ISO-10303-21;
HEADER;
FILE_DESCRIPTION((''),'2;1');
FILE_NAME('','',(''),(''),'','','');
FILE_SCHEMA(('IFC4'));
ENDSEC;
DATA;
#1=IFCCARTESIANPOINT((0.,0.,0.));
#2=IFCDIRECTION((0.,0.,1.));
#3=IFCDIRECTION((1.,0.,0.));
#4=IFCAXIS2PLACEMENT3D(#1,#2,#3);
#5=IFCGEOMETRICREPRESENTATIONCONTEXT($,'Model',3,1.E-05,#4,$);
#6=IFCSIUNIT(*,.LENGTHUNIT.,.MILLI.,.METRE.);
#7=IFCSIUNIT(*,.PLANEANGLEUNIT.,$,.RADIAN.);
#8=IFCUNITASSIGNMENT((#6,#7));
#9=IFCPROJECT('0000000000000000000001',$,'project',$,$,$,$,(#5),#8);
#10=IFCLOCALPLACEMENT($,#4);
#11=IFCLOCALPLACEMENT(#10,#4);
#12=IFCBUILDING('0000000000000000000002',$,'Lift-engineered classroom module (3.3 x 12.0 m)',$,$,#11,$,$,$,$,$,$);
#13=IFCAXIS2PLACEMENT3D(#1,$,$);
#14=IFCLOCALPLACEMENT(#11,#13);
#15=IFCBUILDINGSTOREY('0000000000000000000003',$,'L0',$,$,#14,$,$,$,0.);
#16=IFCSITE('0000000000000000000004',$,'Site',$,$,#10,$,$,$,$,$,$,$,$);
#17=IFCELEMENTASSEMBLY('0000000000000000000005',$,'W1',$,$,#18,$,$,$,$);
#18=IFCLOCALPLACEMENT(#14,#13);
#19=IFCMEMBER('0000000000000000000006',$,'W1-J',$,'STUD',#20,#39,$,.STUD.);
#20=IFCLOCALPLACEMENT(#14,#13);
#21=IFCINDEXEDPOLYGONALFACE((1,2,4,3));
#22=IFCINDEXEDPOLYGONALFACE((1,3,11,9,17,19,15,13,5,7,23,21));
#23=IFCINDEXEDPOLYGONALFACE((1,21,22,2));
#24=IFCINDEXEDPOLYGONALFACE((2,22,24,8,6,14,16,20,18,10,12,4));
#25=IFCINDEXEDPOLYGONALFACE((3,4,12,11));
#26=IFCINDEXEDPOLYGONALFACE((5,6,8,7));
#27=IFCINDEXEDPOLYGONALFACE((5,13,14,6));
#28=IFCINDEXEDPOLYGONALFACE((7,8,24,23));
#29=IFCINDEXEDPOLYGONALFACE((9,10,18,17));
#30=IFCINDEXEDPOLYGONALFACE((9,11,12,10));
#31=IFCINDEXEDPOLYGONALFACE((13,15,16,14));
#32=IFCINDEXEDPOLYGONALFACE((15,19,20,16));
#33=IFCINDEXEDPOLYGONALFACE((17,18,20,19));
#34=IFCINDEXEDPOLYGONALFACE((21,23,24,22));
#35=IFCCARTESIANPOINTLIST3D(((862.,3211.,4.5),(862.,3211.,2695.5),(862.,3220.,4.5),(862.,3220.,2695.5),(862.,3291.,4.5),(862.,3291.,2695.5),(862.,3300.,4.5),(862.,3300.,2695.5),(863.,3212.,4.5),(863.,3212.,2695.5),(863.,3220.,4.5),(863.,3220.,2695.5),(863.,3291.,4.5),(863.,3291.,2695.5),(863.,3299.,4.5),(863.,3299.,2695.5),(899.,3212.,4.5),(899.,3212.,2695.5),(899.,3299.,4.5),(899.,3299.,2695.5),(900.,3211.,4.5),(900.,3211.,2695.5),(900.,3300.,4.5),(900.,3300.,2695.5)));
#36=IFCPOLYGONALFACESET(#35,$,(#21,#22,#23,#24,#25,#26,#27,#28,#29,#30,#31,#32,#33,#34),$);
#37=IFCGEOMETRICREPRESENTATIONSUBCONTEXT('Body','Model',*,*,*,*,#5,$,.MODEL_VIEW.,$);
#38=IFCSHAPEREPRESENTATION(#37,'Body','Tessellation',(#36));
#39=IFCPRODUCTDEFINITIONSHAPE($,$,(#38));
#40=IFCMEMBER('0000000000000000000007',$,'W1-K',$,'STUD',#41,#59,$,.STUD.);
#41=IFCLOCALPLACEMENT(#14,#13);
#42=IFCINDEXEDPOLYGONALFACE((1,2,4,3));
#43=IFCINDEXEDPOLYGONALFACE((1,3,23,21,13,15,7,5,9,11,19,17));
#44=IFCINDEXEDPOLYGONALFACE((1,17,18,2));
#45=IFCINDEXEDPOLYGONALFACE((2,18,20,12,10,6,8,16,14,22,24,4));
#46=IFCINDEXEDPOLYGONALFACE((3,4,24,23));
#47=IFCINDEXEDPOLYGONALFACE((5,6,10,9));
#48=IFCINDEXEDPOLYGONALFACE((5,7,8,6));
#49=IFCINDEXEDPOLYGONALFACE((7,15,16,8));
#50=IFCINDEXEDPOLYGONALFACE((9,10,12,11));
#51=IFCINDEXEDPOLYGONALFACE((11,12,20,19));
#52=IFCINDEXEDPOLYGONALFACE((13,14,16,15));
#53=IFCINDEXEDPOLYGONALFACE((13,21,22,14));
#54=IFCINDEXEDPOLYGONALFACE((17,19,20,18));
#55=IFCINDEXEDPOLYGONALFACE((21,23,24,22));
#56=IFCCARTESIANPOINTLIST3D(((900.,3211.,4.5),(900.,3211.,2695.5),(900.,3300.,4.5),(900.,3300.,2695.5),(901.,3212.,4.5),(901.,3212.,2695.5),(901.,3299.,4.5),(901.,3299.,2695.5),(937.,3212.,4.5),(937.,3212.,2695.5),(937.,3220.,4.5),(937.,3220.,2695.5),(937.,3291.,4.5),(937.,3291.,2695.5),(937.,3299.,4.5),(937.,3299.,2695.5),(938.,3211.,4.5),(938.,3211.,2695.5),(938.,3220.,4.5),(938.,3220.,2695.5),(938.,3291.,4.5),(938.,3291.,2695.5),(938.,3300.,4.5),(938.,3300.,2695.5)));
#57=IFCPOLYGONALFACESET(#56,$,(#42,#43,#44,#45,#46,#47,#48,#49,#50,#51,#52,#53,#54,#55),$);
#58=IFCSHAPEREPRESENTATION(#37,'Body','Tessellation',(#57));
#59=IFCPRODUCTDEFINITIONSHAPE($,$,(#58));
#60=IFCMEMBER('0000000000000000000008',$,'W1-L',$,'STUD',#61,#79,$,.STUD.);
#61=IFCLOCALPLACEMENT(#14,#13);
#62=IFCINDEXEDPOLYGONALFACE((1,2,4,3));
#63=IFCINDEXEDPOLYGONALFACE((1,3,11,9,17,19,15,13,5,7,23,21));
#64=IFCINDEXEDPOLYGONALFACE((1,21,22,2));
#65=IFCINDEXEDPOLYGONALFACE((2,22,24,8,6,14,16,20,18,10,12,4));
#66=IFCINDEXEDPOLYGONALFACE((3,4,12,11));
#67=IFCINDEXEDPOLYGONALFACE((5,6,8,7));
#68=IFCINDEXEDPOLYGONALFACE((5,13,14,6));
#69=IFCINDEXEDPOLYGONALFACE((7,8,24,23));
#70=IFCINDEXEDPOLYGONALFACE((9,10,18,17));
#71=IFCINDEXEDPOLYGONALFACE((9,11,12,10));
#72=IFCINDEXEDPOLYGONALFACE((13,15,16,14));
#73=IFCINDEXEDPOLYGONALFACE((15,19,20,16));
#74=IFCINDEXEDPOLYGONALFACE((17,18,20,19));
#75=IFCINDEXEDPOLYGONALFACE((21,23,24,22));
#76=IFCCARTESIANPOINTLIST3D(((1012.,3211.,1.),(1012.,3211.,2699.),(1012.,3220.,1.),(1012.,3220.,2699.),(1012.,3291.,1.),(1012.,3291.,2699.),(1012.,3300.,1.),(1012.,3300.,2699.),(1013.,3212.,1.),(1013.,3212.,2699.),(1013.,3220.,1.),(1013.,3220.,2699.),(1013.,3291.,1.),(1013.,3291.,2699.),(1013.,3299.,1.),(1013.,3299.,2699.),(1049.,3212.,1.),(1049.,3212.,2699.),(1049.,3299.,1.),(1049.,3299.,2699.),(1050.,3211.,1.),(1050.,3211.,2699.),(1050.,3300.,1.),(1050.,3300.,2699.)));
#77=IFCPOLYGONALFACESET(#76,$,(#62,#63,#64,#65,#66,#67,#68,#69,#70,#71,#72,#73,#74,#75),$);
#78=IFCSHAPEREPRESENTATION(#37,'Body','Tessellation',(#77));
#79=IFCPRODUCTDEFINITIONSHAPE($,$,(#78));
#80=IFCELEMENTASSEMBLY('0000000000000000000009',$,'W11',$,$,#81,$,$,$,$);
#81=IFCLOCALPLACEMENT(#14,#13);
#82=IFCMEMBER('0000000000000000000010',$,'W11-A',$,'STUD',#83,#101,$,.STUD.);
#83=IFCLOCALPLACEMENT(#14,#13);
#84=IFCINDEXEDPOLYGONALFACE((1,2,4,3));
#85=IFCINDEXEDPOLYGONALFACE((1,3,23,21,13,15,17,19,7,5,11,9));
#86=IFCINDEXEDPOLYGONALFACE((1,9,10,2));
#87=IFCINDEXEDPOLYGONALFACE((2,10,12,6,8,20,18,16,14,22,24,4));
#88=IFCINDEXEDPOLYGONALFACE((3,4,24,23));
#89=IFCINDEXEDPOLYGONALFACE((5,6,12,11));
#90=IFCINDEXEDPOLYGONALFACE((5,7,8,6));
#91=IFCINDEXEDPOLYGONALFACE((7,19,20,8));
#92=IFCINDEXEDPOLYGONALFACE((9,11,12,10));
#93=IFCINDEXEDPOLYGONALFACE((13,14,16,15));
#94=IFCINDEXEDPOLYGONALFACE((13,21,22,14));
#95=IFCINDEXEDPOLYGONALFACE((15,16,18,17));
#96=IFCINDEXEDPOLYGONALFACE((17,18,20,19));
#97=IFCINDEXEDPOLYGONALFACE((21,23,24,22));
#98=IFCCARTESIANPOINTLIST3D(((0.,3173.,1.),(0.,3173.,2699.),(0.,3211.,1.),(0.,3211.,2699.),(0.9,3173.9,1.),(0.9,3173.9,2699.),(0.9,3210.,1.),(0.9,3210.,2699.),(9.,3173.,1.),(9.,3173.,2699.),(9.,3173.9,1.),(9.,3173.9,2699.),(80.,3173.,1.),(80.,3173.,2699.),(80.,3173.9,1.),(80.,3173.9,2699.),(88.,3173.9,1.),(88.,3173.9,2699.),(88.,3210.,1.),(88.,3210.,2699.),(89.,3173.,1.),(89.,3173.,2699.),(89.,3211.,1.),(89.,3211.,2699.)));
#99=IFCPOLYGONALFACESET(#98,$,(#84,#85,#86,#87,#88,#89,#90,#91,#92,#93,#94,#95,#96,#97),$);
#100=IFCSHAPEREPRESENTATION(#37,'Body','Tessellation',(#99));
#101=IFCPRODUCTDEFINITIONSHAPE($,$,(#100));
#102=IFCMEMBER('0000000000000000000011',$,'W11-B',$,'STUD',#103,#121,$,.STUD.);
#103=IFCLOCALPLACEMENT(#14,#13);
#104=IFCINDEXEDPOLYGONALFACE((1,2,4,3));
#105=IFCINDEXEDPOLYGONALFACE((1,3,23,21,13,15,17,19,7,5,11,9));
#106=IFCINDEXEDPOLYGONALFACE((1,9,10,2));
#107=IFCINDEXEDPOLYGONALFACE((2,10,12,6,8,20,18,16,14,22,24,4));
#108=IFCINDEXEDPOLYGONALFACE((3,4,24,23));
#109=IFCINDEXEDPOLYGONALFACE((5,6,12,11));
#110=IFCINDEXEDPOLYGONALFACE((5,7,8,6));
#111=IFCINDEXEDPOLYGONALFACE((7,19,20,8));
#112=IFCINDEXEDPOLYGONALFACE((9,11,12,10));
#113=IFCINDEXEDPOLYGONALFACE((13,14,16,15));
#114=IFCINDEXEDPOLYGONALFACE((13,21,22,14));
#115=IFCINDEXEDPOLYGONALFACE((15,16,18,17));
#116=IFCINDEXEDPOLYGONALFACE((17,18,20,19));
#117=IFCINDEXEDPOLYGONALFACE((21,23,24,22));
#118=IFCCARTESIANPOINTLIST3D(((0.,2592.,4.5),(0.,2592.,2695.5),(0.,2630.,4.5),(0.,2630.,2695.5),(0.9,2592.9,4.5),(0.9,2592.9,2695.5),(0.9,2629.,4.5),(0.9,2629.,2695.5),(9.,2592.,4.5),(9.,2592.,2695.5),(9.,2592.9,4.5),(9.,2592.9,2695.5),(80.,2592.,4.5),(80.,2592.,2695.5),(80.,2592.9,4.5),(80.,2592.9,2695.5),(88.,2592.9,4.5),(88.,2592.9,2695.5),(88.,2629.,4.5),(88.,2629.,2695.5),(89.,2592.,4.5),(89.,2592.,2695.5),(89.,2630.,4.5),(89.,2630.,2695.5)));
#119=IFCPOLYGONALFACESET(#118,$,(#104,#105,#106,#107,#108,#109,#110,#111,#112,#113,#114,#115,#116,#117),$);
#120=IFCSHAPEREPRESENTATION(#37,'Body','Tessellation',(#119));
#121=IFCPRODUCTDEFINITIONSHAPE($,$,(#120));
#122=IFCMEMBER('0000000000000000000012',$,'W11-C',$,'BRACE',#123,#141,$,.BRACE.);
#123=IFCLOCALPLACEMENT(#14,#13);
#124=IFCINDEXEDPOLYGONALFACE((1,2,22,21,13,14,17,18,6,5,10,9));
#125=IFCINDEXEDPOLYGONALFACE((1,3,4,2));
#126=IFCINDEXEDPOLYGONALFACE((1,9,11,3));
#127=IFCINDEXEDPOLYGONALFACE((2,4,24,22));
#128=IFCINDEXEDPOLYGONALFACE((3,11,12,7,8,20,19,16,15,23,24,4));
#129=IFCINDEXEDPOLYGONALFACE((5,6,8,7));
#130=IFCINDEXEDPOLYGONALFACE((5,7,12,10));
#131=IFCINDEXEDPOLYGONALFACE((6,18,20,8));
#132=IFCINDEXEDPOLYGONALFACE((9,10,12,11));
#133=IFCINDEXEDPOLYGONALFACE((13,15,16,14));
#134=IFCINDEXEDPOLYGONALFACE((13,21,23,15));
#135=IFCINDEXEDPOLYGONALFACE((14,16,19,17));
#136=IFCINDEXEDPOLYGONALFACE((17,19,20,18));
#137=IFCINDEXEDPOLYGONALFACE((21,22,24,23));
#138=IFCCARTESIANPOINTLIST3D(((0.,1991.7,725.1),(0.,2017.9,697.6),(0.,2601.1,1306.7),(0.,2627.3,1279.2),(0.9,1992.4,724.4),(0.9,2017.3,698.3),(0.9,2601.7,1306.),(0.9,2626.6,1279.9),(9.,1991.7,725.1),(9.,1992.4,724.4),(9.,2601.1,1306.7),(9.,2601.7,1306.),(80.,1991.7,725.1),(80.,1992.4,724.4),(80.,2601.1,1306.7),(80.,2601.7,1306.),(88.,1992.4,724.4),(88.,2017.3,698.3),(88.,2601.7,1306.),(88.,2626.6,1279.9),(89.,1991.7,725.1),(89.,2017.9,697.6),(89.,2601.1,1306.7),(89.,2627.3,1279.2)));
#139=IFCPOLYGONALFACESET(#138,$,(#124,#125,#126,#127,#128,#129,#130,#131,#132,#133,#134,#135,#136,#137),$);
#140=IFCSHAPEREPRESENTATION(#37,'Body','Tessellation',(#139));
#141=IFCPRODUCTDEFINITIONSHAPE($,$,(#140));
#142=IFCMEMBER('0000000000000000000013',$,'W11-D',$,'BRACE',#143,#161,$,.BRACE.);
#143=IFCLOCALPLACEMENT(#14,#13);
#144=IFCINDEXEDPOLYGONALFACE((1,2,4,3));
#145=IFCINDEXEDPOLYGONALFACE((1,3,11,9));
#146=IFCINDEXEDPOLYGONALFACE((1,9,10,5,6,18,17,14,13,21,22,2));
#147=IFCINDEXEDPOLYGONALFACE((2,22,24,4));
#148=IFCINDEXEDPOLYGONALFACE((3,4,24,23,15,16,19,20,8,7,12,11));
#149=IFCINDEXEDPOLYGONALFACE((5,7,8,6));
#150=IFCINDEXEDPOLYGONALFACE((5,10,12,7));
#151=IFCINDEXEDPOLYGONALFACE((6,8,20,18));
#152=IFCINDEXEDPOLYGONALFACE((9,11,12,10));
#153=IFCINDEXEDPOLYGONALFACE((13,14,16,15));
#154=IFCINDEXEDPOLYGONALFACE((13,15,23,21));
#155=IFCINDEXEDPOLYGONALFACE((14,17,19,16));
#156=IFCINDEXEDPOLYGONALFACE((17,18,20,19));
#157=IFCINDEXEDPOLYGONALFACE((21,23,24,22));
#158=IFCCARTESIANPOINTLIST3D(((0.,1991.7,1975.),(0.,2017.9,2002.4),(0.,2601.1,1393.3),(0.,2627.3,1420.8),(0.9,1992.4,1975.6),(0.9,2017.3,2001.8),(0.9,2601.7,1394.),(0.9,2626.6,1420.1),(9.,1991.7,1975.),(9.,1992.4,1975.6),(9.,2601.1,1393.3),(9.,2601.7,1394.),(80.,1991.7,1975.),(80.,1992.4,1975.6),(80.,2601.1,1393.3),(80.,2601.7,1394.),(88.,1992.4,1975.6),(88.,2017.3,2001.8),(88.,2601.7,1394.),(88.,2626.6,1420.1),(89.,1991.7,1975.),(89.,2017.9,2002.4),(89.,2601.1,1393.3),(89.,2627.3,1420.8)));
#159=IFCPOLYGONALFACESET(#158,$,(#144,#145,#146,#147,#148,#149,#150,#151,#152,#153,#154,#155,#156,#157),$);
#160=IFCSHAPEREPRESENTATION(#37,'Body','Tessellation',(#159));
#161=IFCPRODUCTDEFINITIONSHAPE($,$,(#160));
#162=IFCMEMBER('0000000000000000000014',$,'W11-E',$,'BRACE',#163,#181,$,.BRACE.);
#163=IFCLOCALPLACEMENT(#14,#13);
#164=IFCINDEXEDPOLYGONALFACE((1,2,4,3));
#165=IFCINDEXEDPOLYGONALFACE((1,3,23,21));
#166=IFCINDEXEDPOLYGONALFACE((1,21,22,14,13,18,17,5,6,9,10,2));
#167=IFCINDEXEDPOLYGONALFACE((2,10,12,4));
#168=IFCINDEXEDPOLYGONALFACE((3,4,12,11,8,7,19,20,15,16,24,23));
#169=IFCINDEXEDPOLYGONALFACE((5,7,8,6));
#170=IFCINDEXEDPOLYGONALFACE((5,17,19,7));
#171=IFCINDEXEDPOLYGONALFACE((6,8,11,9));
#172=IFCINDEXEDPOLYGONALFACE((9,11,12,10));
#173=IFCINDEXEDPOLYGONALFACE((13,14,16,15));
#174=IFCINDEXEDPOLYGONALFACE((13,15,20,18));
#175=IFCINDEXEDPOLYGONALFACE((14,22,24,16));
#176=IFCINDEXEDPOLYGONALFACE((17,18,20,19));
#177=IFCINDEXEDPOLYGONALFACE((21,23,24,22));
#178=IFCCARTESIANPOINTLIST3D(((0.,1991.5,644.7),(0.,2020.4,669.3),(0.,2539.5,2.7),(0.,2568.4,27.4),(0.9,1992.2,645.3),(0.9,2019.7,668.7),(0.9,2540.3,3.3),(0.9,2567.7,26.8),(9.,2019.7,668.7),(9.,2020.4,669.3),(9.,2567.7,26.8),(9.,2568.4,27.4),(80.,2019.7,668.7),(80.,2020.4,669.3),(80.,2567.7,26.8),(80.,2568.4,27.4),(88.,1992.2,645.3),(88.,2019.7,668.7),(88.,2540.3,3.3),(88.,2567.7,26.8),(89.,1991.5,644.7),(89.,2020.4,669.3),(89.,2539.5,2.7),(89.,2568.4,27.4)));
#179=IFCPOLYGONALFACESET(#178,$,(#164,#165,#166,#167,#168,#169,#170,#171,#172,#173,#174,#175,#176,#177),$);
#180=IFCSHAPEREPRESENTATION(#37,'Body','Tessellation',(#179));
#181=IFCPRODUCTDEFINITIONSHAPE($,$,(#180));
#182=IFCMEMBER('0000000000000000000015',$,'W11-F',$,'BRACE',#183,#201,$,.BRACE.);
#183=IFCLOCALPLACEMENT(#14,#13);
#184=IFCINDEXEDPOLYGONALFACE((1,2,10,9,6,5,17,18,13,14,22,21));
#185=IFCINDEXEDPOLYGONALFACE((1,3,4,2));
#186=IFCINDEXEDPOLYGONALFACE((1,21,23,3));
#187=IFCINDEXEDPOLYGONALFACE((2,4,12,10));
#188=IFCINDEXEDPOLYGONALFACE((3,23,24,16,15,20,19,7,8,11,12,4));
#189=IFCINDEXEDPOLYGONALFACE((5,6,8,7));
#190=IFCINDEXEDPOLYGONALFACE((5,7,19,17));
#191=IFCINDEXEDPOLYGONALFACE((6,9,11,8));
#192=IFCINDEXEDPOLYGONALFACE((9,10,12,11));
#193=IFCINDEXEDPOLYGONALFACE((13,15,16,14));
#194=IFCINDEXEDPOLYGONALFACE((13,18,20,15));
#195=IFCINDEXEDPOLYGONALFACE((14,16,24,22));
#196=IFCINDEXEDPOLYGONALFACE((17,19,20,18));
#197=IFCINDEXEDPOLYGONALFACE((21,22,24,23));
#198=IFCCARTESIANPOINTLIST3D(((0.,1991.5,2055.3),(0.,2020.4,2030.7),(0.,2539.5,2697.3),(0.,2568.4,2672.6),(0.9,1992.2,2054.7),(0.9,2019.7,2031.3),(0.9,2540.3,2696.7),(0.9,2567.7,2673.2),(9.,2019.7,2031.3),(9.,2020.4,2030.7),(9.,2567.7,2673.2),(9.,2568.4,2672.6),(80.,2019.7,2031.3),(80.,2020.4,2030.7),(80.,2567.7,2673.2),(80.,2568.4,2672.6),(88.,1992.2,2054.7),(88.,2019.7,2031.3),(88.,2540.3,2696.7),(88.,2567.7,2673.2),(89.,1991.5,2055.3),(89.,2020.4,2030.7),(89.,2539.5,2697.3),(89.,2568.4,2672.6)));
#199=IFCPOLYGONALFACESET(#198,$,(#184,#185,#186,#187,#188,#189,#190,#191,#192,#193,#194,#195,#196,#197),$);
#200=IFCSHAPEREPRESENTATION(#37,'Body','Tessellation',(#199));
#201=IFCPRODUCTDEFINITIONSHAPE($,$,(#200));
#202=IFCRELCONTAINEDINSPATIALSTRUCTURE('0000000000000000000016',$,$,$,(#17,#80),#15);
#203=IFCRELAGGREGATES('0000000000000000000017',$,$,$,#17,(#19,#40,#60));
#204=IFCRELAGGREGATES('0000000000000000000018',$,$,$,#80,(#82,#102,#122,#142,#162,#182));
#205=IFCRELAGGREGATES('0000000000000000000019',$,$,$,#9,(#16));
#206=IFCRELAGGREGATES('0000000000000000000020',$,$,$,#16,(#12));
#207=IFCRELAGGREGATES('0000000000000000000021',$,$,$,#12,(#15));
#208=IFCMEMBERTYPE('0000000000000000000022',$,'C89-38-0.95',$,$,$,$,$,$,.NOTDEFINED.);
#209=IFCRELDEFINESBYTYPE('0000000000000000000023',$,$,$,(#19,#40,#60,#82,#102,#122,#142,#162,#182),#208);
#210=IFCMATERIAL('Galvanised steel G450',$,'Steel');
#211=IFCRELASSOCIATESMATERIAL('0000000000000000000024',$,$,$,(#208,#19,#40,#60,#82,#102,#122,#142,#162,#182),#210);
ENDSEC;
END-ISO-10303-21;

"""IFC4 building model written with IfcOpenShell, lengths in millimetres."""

from ifc_helpers import new_model, si_unit, frame, origin, origin_with_axes, origin_2d, place, context, subcontext, project, spatial, c_section, extrude, material, material_profile, profile_set, profile_usage, type_object, element, aggregate, save


model = new_model("IFC4")

# Units and contexts
model_context = context("Model", 3, precision=1e-05, world=origin_with_axes())
body_context = subcontext(model_context, "Body", "Model", "MODEL_VIEW")
ifc_project = project(units=[si_unit("LENGTHUNIT", "METRE", prefix="MILLI"), si_unit("PLANEANGLEUNIT", "RADIAN")], contexts=[model_context])

# Site, building, storey
site_placement = place(None, origin_with_axes())
site = spatial("IfcSite", under=ifc_project, at=site_placement, Name="Site")
building_placement = place(site_placement, origin_with_axes())
building = spatial("IfcBuilding", under=site, at=building_placement, Name="Lift-engineered classroom module (3.3 x 12.0 m)")
storey_placement = place(building_placement, origin())
storey = spatial("IfcBuildingStorey", under=building, at=storey_placement, Name="L0", Elevation=0.0)

# Element assemblies, members
assembly_1_placement = place(storey_placement, frame((0.0, 3255.5, 0.0)))
assembly_1 = element("IfcElementAssembly", 1, at=assembly_1_placement, inside=storey, Name="W1")
ifc_material = material(Name="Galvanised steel G450", Category="Steel")
ifc_material_profile = material_profile(ifc_material, c_section(Depth=89.0, Width=38.0, WallThickness=0.9, Girth=9.0, at=origin_2d()), Name="C89-38-0.95")
ifc_profile_set = profile_set([ifc_material_profile], Name="C89-38-0.95")
ifc_profile_usage = profile_usage(ifc_profile_set)
member_type = type_object("IfcMemberType", Name="C89-38-0.95", PredefinedType="NOTDEFINED", material=ifc_profile_set)
member_1_placement = place(assembly_1_placement, frame((881.0, 0.0, 4.5), z_axis=(0.0, 0.0, 1.0), x_axis=(-1.0, 0.0, 0.0)))
member_1 = element("IfcMember", 2, at=member_1_placement, type_object=member_type, material=ifc_profile_usage, Name="W1-J", ObjectType="STUD", PredefinedType="STUD", context=body_context, shape_type="SweptSolid", body=[
    extrude(c_section(Depth=89.0, Width=38.0, WallThickness=0.9, Girth=9.0, at=origin_2d()), origin(), (0.0, 0.0, 1.0), 2691.0),
])
member_2_placement = place(assembly_1_placement, frame((919.0, 0.0, 2695.5), z_axis=(0.0, 0.0, -1.0), x_axis=(1.0, 0.0, 0.0)))
member_2 = element("IfcMember", 3, at=member_2_placement, type_object=member_type, material=ifc_profile_usage, Name="W1-K", ObjectType="STUD", PredefinedType="STUD", context=body_context, shape_type="SweptSolid", body=[
    extrude(c_section(Depth=89.0, Width=38.0, WallThickness=0.9, Girth=9.0, at=origin_2d()), origin(), (0.0, 0.0, 1.0), 2691.0),
])
member_3_placement = place(assembly_1_placement, frame((1031.0, 0.0, 0.9), z_axis=(0.0, 0.0, 1.0), x_axis=(-1.0, 0.0, 0.0)))
member_3 = element("IfcMember", 4, at=member_3_placement, type_object=member_type, material=ifc_profile_usage, Name="W1-L", ObjectType="STUD", PredefinedType="STUD", context=body_context, shape_type="SweptSolid", body=[
    extrude(c_section(Depth=89.0, Width=38.0, WallThickness=0.9, Girth=9.0, at=origin_2d()), origin(), (0.0, 0.0, 1.0), 2698.1),
])
aggregate(assembly_1, [member_1, member_2, member_3])
assembly_2_placement = place(storey_placement, frame((44.5, 3211.0, 0.0)))
assembly_2 = element("IfcElementAssembly", 5, at=assembly_2_placement, inside=storey, Name="W11")
member_4_placement = place(assembly_2_placement, frame((0.0, -19.0, 2699.1), z_axis=(0.0, 0.0, -1.0), x_axis=(0.0, -1.0, 0.0)))
member_4 = element("IfcMember", 6, at=member_4_placement, type_object=member_type, material=ifc_profile_usage, Name="W11-A", ObjectType="STUD", PredefinedType="STUD", context=body_context, shape_type="SweptSolid", body=[
    extrude(c_section(Depth=89.0, Width=38.0, WallThickness=0.9, Girth=9.0, at=origin_2d()), origin(), (0.0, 0.0, 1.0), 2698.1),
])
member_5_placement = place(assembly_2_placement, frame((0.0, -600.0, 2695.5), z_axis=(0.0, 0.0, -1.0), x_axis=(0.0, -1.0, 0.0)))
member_5 = element("IfcMember", 7, at=member_5_placement, type_object=member_type, material=ifc_profile_usage, Name="W11-B", ObjectType="STUD", PredefinedType="STUD", context=body_context, shape_type="SweptSolid", body=[
    extrude(c_section(Depth=89.0, Width=38.0, WallThickness=0.9, Girth=9.0, at=origin_2d()), origin(), (0.0, 0.0, 1.0), 2691.0),
])
member_6_placement = place(assembly_2_placement, frame((0.0, -596.8, 1293.0), z_axis=(0.0, -0.723356, -0.690475), x_axis=(0.0, -0.690475, 0.723356)))
member_6 = element("IfcMember", 8, at=member_6_placement, type_object=member_type, material=ifc_profile_usage, Name="W11-C", ObjectType="BRACE", PredefinedType="BRACE", context=body_context, shape_type="SweptSolid", body=[
    extrude(c_section(Depth=89.0, Width=38.0, WallThickness=0.9, Girth=9.0, at=origin_2d()), origin(), (0.0, 0.0, 1.0), 842.4),
])
member_7_placement = place(assembly_2_placement, frame((0.0, -1206.2, 1988.7), z_axis=(0.0, 0.723356, -0.690475), x_axis=(0.0, -0.690475, -0.723356)))
member_7 = element("IfcMember", 9, at=member_7_placement, type_object=member_type, material=ifc_profile_usage, Name="W11-D", ObjectType="BRACE", PredefinedType="BRACE", context=body_context, shape_type="SweptSolid", body=[
    extrude(c_section(Depth=89.0, Width=38.0, WallThickness=0.9, Girth=9.0, at=origin_2d()), origin(), (0.0, 0.0, 1.0), 842.4),
])
member_8_placement = place(assembly_2_placement, frame((0.0, -657.0, 15.0), z_axis=(0.0, -0.649267, 0.760561), x_axis=(0.0, 0.760561, 0.649267)))
member_8 = element("IfcMember", 10, at=member_8_placement, type_object=member_type, material=ifc_profile_usage, Name="W11-E", ObjectType="BRACE", PredefinedType="BRACE", context=body_context, shape_type="SweptSolid", body=[
    extrude(c_section(Depth=89.0, Width=38.0, WallThickness=0.9, Girth=9.0, at=origin_2d()), origin(), (0.0, 0.0, 1.0), 844.1),
])
member_9_placement = place(assembly_2_placement, frame((0.0, -1205.1, 2043.0), z_axis=(0.0, 0.649267, 0.760561), x_axis=(0.0, 0.760561, -0.649267)))
member_9 = element("IfcMember", 11, at=member_9_placement, type_object=member_type, material=ifc_profile_usage, Name="W11-F", ObjectType="BRACE", PredefinedType="BRACE", context=body_context, shape_type="SweptSolid", body=[
    extrude(c_section(Depth=89.0, Width=38.0, WallThickness=0.9, Girth=9.0, at=origin_2d()), origin(), (0.0, 0.0, 1.0), 844.1),
])
aggregate(assembly_2, [member_4, member_5, member_6, member_7, member_8, member_9])

save(model, "model.ifc")
